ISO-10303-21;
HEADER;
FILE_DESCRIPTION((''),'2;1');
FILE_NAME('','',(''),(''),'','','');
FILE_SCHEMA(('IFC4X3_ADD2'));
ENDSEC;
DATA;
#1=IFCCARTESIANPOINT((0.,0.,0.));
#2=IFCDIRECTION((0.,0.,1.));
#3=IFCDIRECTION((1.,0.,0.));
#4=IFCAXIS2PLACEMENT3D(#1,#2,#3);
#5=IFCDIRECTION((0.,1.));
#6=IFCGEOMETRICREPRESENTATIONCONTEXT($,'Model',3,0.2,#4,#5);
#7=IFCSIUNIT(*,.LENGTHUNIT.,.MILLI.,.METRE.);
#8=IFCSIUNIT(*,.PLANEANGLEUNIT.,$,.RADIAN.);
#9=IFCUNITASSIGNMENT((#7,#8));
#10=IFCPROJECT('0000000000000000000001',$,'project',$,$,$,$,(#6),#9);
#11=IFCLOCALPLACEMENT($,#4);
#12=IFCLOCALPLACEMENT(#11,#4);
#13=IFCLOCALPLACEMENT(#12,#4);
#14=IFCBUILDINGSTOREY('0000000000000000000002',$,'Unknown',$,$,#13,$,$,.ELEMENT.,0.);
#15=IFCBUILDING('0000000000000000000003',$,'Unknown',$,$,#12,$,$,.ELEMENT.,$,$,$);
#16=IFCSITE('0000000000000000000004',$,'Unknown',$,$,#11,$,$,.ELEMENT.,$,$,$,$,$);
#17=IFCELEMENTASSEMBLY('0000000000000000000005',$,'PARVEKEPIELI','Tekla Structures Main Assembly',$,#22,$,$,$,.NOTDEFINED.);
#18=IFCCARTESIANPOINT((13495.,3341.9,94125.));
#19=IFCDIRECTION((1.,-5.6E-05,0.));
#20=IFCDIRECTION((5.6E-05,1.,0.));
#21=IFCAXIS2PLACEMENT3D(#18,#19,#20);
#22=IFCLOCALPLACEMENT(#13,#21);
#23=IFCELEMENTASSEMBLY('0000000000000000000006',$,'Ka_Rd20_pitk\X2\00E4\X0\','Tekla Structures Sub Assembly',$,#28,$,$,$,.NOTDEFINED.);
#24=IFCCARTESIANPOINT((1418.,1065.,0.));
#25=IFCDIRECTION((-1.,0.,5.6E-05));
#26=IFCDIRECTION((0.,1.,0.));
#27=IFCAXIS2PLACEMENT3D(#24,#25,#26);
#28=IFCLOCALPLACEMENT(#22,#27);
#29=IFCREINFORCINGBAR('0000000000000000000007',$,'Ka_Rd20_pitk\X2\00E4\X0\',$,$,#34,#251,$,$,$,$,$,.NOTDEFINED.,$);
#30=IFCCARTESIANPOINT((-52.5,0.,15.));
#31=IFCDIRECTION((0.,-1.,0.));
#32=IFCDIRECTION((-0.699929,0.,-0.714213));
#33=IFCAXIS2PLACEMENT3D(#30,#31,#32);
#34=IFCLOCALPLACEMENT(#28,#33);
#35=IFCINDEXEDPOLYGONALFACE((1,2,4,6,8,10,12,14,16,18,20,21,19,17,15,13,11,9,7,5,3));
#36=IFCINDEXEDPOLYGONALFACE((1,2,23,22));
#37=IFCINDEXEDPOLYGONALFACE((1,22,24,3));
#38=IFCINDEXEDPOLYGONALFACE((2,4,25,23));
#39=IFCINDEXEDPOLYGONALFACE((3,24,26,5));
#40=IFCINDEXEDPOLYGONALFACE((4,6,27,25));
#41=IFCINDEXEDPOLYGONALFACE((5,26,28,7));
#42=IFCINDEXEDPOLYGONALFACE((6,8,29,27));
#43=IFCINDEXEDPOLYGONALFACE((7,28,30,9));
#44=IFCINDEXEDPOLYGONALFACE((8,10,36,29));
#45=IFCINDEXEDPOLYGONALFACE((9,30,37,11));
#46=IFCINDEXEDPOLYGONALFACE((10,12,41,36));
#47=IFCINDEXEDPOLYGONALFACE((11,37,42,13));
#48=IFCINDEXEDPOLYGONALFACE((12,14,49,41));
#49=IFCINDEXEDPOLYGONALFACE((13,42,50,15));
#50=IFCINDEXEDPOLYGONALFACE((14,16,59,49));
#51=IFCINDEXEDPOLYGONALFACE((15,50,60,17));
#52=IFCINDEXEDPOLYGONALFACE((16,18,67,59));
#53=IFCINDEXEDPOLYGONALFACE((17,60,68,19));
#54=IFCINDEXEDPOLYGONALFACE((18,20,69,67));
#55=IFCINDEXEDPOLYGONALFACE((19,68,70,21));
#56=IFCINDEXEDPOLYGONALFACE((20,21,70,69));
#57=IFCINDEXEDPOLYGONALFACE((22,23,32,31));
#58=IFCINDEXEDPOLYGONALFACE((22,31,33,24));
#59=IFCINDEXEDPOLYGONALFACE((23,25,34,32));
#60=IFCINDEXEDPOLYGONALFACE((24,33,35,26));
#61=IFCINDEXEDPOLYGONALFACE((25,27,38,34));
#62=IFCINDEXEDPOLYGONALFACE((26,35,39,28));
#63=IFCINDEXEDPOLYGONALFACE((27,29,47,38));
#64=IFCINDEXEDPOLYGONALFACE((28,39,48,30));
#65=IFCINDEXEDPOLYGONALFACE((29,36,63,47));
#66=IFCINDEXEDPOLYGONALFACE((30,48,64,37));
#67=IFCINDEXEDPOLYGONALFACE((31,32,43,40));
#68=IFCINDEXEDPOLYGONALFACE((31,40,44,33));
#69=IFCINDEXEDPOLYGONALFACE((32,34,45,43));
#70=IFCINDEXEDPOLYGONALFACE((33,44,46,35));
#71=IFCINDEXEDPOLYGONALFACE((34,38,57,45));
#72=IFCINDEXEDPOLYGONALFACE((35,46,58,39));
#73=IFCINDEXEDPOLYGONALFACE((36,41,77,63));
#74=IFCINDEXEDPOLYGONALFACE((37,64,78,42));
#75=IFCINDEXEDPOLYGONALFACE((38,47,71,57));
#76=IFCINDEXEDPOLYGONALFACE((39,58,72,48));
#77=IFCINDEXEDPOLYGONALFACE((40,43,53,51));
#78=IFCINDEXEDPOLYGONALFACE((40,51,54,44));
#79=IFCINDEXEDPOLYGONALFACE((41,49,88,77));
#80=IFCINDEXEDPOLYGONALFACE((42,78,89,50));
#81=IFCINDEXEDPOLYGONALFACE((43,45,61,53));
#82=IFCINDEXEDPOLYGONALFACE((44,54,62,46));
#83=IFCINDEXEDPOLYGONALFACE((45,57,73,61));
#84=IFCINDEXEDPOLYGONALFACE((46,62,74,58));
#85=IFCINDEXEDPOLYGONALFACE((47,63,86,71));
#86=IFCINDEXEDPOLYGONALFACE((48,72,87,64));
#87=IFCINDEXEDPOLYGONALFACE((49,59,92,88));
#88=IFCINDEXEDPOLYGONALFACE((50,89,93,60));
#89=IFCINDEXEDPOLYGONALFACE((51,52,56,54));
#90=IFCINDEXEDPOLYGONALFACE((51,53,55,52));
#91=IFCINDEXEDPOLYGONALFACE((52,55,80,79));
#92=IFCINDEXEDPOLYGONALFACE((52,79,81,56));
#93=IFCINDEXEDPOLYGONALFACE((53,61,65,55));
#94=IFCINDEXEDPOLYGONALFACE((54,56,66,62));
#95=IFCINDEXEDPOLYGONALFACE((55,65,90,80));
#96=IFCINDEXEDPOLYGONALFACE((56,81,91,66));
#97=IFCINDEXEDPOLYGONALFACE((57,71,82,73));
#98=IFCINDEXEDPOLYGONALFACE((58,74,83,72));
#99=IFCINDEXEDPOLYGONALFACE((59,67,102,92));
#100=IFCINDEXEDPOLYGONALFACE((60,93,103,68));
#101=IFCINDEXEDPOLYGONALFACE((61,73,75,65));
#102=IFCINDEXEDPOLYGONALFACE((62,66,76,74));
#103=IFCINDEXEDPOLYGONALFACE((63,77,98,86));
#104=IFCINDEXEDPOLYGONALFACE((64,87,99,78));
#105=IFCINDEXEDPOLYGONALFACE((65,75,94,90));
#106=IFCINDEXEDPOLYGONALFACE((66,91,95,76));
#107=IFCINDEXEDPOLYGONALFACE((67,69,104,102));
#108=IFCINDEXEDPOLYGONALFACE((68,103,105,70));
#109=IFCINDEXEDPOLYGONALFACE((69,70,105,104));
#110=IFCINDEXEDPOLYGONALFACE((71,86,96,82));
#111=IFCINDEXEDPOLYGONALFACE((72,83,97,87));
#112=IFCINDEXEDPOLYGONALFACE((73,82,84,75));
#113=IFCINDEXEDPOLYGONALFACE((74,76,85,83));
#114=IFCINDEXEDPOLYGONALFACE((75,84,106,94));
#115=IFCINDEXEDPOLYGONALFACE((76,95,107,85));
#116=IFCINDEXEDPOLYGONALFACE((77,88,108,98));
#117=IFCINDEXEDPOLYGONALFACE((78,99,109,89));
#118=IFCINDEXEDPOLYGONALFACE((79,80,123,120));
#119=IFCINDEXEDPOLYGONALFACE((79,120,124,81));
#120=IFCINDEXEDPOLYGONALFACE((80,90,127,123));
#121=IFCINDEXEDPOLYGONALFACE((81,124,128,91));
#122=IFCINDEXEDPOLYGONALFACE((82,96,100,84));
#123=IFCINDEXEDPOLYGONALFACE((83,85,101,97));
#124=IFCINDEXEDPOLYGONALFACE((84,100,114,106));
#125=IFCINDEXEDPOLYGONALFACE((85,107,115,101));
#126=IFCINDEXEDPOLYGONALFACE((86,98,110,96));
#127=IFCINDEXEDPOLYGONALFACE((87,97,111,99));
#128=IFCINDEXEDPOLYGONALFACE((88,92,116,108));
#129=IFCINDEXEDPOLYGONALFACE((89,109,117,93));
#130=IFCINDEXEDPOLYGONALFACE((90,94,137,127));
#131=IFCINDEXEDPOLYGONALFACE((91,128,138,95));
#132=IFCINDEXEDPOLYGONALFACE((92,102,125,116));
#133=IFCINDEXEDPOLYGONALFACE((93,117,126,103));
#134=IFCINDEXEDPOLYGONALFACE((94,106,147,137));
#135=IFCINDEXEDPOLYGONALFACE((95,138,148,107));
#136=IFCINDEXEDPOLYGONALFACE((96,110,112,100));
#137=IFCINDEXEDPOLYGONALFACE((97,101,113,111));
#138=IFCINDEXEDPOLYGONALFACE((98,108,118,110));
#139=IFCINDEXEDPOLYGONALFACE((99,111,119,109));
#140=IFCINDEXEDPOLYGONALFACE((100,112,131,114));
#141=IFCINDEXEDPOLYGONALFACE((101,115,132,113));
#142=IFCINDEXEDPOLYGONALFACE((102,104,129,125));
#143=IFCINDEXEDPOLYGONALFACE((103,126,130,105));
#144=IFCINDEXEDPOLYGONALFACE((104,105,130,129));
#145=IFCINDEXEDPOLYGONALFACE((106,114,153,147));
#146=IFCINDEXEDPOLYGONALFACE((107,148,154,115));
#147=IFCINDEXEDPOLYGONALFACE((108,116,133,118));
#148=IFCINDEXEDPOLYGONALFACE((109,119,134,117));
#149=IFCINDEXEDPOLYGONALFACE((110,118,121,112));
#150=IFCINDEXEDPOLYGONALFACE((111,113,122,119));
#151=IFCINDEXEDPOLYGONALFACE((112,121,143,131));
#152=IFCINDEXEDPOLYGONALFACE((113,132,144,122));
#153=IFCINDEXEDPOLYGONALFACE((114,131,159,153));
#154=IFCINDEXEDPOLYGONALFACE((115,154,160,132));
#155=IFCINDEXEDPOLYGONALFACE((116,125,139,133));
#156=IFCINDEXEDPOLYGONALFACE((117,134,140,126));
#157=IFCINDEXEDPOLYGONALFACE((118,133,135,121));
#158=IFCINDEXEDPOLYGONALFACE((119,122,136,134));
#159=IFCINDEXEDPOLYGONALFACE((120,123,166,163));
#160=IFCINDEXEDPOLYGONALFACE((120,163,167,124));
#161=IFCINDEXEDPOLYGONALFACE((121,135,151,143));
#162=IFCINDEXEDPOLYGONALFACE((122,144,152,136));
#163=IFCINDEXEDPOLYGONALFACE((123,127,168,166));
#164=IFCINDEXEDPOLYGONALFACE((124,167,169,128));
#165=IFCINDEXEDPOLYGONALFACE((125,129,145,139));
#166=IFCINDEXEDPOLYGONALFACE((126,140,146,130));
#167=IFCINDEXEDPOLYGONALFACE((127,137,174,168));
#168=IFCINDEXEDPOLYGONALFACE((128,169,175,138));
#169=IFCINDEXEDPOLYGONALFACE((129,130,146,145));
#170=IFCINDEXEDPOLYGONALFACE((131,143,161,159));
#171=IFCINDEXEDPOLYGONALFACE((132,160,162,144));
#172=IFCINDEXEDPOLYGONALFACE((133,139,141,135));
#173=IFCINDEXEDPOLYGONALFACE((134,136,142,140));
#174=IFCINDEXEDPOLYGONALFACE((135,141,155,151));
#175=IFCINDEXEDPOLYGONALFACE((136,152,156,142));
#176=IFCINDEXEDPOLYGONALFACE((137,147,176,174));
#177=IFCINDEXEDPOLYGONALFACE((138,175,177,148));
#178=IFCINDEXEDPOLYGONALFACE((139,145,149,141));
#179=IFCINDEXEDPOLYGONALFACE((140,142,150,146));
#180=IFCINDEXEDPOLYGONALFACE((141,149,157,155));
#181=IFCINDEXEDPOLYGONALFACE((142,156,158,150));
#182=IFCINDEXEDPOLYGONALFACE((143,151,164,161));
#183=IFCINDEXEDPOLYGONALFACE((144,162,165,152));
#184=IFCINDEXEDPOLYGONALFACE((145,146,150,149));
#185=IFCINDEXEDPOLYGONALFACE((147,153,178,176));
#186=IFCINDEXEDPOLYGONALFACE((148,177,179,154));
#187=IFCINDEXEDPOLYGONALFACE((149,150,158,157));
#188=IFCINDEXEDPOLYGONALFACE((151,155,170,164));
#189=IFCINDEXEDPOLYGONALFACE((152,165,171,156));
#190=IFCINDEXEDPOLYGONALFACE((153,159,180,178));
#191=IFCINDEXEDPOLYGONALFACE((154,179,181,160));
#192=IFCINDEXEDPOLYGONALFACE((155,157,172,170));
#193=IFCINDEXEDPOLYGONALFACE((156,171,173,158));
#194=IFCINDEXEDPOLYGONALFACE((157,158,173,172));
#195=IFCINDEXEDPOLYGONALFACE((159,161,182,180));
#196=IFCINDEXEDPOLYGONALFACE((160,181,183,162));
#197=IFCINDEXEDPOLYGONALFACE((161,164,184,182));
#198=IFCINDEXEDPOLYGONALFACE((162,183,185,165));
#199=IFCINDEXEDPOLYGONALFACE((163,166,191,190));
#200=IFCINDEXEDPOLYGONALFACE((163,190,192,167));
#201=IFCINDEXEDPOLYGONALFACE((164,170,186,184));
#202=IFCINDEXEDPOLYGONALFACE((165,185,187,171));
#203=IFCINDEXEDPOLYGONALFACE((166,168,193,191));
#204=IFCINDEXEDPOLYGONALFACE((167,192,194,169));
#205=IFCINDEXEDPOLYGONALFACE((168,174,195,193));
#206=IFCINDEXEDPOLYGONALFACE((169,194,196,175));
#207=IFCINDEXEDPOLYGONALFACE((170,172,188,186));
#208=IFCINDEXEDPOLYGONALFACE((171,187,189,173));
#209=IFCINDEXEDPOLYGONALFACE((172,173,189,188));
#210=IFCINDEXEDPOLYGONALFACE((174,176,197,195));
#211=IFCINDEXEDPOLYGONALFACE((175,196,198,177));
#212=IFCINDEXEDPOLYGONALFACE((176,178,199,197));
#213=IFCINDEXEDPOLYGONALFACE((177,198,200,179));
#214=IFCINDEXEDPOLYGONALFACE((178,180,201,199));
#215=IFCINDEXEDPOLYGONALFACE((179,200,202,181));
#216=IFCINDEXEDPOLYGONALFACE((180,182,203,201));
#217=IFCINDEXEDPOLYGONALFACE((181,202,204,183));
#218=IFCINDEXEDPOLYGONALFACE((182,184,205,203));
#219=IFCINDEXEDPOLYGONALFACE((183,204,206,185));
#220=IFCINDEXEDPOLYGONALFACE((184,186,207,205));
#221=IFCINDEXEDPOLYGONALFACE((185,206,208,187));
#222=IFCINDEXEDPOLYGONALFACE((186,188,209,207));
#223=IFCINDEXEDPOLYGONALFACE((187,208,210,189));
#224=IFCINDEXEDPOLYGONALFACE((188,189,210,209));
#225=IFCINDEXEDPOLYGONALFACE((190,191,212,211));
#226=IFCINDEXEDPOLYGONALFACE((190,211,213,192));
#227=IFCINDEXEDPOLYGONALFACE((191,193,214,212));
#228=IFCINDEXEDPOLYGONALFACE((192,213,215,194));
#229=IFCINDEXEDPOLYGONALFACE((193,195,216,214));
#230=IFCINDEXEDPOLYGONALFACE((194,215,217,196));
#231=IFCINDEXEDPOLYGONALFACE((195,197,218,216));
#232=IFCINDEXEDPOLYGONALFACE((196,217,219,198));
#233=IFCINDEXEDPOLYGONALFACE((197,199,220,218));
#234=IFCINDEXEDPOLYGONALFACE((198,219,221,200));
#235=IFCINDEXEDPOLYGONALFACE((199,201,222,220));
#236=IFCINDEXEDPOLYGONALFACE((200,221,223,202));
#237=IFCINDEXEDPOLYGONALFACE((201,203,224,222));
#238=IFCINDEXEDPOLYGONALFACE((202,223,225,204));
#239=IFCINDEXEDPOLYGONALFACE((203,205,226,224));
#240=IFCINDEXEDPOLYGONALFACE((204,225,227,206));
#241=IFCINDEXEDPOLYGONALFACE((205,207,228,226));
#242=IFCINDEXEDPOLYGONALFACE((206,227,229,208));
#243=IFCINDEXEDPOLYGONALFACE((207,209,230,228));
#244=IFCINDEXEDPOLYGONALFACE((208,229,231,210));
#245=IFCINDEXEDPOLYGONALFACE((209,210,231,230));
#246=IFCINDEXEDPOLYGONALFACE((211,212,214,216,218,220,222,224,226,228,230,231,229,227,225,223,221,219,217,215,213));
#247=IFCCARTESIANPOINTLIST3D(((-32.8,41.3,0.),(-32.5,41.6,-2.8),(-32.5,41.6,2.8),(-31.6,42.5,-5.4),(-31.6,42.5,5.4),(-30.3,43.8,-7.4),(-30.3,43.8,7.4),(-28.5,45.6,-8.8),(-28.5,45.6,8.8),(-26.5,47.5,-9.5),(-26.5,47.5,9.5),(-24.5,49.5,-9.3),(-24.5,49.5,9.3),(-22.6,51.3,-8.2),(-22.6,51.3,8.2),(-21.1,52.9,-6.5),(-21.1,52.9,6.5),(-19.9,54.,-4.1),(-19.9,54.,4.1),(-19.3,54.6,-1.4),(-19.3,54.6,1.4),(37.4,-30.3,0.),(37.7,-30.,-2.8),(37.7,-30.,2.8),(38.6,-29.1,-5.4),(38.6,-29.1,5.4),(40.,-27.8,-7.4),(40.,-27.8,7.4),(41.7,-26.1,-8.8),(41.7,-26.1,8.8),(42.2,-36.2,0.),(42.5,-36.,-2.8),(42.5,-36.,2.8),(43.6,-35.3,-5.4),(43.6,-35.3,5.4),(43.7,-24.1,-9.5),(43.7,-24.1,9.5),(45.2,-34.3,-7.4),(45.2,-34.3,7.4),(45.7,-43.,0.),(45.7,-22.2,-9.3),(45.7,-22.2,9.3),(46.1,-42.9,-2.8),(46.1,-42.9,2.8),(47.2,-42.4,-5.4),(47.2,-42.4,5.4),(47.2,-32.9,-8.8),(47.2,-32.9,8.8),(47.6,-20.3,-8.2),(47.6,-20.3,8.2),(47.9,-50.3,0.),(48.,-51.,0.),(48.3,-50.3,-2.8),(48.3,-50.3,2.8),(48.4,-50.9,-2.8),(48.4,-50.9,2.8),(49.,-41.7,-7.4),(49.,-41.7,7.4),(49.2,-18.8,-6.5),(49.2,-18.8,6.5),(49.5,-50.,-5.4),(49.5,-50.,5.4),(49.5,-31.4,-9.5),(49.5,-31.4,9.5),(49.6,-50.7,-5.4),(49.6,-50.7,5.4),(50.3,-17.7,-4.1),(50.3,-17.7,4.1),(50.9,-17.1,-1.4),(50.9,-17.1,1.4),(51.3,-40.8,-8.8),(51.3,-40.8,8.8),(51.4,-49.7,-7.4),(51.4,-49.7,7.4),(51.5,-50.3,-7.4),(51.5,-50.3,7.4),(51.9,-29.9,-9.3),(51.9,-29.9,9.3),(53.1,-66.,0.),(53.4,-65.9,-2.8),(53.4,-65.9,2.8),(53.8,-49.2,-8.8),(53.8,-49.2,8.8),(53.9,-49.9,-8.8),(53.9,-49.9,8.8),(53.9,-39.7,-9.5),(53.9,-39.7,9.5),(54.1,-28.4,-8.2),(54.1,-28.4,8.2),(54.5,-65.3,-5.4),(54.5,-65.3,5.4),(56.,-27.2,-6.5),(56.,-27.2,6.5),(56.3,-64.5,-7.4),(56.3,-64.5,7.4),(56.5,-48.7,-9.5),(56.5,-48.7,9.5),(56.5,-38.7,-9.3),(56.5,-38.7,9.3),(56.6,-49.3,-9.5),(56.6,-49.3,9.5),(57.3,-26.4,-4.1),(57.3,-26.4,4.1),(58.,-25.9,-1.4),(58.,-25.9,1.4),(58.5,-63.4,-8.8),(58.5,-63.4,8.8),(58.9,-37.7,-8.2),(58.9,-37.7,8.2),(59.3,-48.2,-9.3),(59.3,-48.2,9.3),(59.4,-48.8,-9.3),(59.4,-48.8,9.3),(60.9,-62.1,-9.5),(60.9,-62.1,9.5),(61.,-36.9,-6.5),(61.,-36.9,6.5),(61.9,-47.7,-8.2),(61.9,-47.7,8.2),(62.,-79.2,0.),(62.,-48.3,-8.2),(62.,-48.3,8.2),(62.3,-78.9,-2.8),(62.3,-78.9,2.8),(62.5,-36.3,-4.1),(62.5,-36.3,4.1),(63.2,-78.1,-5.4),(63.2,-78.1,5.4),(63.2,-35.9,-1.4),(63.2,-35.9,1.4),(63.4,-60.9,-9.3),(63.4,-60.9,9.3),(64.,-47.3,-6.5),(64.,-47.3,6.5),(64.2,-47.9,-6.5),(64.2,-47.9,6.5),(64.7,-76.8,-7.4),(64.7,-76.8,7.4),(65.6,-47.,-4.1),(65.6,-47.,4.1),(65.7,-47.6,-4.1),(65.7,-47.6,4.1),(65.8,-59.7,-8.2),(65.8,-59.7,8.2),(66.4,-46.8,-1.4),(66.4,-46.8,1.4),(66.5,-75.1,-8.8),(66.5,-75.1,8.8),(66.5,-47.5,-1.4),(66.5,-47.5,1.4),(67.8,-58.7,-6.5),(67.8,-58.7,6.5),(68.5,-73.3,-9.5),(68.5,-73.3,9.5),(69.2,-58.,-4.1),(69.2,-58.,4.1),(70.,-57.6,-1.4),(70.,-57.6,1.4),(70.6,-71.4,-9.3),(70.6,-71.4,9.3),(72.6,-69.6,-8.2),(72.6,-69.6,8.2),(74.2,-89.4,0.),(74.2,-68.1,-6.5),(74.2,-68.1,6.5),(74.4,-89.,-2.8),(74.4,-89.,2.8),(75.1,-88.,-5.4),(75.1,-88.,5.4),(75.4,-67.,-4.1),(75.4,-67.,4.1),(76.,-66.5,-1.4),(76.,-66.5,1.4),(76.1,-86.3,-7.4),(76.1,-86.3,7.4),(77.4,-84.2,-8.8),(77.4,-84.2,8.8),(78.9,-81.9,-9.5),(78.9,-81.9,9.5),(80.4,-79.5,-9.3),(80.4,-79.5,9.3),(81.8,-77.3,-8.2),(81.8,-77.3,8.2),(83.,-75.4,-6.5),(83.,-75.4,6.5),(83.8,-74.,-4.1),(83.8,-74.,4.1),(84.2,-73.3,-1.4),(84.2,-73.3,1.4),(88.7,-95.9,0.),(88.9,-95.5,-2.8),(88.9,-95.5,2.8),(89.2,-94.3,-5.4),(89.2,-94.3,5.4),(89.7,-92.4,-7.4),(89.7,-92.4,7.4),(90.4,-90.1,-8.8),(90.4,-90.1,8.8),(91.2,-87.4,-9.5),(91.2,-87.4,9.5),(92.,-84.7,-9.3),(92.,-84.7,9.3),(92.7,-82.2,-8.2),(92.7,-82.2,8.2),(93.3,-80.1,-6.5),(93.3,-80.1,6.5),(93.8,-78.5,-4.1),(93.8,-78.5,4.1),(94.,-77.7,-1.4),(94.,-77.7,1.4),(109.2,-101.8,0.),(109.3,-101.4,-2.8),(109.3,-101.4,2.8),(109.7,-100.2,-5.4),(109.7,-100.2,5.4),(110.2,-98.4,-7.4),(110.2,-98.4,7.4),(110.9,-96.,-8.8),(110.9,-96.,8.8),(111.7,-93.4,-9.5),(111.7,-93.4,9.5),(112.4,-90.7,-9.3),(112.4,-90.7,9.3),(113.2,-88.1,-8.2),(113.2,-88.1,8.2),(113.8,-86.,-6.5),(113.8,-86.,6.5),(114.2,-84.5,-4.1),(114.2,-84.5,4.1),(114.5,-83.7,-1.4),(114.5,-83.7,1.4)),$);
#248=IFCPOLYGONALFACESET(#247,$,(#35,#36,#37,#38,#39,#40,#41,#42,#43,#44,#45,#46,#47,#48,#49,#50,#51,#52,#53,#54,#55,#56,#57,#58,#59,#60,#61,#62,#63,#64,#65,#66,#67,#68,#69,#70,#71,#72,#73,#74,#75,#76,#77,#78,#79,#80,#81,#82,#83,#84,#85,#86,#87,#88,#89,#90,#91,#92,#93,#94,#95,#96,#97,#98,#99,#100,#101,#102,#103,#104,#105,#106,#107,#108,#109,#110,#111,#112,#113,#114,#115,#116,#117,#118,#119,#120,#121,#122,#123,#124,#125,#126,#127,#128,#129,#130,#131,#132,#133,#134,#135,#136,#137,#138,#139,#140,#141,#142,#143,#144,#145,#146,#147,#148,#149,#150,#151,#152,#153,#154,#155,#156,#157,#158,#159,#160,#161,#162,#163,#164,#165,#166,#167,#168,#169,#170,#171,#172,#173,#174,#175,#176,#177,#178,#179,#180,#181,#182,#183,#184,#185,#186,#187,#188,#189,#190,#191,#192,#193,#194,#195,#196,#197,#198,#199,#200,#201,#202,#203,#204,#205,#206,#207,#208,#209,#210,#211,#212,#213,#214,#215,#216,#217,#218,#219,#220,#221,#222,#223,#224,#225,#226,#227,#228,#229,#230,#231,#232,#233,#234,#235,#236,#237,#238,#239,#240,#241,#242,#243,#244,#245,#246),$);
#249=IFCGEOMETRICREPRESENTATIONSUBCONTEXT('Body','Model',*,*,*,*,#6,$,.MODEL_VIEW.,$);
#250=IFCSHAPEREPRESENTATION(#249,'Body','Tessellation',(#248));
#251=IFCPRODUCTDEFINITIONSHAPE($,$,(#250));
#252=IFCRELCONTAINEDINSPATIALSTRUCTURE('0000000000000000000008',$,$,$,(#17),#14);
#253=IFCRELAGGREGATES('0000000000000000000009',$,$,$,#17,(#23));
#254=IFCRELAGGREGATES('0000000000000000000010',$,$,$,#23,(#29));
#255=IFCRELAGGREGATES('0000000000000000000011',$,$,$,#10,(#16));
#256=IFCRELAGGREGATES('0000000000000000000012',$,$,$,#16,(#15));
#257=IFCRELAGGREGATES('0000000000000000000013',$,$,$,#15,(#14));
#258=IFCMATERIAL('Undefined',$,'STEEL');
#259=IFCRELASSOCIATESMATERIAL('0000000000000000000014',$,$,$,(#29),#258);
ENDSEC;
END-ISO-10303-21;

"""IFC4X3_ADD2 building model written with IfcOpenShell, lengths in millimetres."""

from ifc_helpers import new_model, entity, si_unit, direction, frame, origin_with_axes, place, context, subcontext, project, spatial, material, element, aggregate, save


model = new_model("IFC4X3_ADD2")

# Units and contexts
model_context = context("Model", 3, precision=0.2, world=origin_with_axes(), true_north=direction((0.0, 1.0)))
body_context = subcontext(model_context, "Body", "Model", "MODEL_VIEW")
ifc_project = project(units=[si_unit("LENGTHUNIT", "METRE", prefix="MILLI"), si_unit("PLANEANGLEUNIT", "RADIAN")], contexts=[model_context])

# Site, building, storey
site_placement = place(None, origin_with_axes())
site = spatial("IfcSite", under=ifc_project, at=site_placement, Name="Unknown", CompositionType="ELEMENT")
building_placement = place(site_placement, origin_with_axes())
building = spatial("IfcBuilding", under=site, at=building_placement, Name="Unknown", CompositionType="ELEMENT")
storey_placement = place(building_placement, origin_with_axes())
storey = spatial("IfcBuildingStorey", under=building, at=storey_placement, Name="Unknown", CompositionType="ELEMENT", Elevation=0.0)

# Element assemblies
assembly_1_placement = place(storey_placement, frame((13495.0, 3341.9, 94125.0), z_axis=(1.0, -0.000056, 0.0), x_axis=(0.000056, 1.0, 0.0)))
assembly_1 = element("IfcElementAssembly", 1, at=assembly_1_placement, inside=storey, Name="PARVEKEPIELI", Description="Tekla Structures Main Assembly", PredefinedType="NOTDEFINED")
assembly_2_placement = place(assembly_1_placement, frame((1418.0, 1065.0, 0.0), z_axis=(-1.0, 0.0, 0.000056), x_axis=(0.0, 1.0, 0.0)))
assembly_2 = element("IfcElementAssembly", 2, at=assembly_2_placement, Name="Ka_Rd20_pitkä", Description="Tekla Structures Sub Assembly", PredefinedType="NOTDEFINED")

aggregate(assembly_1, [assembly_2])

# Reinforcing bar
ifc_material_1 = material(Name="Undefined", Category="STEEL")
reinforcing_bar_1_placement = place(assembly_2_placement, frame((-52.5, 0.0, 15.0), z_axis=(0.0, -1.0, 0.0), x_axis=(-0.699929, 0.0, -0.714213)))
reinforcing_bar_1 = element("IfcReinforcingBar", 3, at=reinforcing_bar_1_placement, material=ifc_material_1, Name="Ka_Rd20_pitkä", PredefinedType="NOTDEFINED", context=body_context, shape_type="AdvancedSweptSolid", body=[
    entity("IfcSweptDiskSolid", entity("IfcIndexedPolyCurve", entity("IfcCartesianPointList3D", [[-26.0, 48.0, 0.0], [44.2, -23.7, 0.0], [52.5, -35.1, 0.0], [57.2, -48.6, 0.0], [57.3, -49.2, 0.0], [69.1, -72.8, 0.0], [91.4, -86.7, 0.0], [111.9, -92.7, 0.0]]), [entity("IfcLineIndex", [1, 2]), entity("IfcArcIndex", [2, 3, 4]), entity("IfcLineIndex", [4, 5]), entity("IfcArcIndex", [5, 6, 7]), entity("IfcLineIndex", [7, 8])]), 9.5),
])
aggregate(assembly_2, [reinforcing_bar_1])

save(model, "model.ifc")
